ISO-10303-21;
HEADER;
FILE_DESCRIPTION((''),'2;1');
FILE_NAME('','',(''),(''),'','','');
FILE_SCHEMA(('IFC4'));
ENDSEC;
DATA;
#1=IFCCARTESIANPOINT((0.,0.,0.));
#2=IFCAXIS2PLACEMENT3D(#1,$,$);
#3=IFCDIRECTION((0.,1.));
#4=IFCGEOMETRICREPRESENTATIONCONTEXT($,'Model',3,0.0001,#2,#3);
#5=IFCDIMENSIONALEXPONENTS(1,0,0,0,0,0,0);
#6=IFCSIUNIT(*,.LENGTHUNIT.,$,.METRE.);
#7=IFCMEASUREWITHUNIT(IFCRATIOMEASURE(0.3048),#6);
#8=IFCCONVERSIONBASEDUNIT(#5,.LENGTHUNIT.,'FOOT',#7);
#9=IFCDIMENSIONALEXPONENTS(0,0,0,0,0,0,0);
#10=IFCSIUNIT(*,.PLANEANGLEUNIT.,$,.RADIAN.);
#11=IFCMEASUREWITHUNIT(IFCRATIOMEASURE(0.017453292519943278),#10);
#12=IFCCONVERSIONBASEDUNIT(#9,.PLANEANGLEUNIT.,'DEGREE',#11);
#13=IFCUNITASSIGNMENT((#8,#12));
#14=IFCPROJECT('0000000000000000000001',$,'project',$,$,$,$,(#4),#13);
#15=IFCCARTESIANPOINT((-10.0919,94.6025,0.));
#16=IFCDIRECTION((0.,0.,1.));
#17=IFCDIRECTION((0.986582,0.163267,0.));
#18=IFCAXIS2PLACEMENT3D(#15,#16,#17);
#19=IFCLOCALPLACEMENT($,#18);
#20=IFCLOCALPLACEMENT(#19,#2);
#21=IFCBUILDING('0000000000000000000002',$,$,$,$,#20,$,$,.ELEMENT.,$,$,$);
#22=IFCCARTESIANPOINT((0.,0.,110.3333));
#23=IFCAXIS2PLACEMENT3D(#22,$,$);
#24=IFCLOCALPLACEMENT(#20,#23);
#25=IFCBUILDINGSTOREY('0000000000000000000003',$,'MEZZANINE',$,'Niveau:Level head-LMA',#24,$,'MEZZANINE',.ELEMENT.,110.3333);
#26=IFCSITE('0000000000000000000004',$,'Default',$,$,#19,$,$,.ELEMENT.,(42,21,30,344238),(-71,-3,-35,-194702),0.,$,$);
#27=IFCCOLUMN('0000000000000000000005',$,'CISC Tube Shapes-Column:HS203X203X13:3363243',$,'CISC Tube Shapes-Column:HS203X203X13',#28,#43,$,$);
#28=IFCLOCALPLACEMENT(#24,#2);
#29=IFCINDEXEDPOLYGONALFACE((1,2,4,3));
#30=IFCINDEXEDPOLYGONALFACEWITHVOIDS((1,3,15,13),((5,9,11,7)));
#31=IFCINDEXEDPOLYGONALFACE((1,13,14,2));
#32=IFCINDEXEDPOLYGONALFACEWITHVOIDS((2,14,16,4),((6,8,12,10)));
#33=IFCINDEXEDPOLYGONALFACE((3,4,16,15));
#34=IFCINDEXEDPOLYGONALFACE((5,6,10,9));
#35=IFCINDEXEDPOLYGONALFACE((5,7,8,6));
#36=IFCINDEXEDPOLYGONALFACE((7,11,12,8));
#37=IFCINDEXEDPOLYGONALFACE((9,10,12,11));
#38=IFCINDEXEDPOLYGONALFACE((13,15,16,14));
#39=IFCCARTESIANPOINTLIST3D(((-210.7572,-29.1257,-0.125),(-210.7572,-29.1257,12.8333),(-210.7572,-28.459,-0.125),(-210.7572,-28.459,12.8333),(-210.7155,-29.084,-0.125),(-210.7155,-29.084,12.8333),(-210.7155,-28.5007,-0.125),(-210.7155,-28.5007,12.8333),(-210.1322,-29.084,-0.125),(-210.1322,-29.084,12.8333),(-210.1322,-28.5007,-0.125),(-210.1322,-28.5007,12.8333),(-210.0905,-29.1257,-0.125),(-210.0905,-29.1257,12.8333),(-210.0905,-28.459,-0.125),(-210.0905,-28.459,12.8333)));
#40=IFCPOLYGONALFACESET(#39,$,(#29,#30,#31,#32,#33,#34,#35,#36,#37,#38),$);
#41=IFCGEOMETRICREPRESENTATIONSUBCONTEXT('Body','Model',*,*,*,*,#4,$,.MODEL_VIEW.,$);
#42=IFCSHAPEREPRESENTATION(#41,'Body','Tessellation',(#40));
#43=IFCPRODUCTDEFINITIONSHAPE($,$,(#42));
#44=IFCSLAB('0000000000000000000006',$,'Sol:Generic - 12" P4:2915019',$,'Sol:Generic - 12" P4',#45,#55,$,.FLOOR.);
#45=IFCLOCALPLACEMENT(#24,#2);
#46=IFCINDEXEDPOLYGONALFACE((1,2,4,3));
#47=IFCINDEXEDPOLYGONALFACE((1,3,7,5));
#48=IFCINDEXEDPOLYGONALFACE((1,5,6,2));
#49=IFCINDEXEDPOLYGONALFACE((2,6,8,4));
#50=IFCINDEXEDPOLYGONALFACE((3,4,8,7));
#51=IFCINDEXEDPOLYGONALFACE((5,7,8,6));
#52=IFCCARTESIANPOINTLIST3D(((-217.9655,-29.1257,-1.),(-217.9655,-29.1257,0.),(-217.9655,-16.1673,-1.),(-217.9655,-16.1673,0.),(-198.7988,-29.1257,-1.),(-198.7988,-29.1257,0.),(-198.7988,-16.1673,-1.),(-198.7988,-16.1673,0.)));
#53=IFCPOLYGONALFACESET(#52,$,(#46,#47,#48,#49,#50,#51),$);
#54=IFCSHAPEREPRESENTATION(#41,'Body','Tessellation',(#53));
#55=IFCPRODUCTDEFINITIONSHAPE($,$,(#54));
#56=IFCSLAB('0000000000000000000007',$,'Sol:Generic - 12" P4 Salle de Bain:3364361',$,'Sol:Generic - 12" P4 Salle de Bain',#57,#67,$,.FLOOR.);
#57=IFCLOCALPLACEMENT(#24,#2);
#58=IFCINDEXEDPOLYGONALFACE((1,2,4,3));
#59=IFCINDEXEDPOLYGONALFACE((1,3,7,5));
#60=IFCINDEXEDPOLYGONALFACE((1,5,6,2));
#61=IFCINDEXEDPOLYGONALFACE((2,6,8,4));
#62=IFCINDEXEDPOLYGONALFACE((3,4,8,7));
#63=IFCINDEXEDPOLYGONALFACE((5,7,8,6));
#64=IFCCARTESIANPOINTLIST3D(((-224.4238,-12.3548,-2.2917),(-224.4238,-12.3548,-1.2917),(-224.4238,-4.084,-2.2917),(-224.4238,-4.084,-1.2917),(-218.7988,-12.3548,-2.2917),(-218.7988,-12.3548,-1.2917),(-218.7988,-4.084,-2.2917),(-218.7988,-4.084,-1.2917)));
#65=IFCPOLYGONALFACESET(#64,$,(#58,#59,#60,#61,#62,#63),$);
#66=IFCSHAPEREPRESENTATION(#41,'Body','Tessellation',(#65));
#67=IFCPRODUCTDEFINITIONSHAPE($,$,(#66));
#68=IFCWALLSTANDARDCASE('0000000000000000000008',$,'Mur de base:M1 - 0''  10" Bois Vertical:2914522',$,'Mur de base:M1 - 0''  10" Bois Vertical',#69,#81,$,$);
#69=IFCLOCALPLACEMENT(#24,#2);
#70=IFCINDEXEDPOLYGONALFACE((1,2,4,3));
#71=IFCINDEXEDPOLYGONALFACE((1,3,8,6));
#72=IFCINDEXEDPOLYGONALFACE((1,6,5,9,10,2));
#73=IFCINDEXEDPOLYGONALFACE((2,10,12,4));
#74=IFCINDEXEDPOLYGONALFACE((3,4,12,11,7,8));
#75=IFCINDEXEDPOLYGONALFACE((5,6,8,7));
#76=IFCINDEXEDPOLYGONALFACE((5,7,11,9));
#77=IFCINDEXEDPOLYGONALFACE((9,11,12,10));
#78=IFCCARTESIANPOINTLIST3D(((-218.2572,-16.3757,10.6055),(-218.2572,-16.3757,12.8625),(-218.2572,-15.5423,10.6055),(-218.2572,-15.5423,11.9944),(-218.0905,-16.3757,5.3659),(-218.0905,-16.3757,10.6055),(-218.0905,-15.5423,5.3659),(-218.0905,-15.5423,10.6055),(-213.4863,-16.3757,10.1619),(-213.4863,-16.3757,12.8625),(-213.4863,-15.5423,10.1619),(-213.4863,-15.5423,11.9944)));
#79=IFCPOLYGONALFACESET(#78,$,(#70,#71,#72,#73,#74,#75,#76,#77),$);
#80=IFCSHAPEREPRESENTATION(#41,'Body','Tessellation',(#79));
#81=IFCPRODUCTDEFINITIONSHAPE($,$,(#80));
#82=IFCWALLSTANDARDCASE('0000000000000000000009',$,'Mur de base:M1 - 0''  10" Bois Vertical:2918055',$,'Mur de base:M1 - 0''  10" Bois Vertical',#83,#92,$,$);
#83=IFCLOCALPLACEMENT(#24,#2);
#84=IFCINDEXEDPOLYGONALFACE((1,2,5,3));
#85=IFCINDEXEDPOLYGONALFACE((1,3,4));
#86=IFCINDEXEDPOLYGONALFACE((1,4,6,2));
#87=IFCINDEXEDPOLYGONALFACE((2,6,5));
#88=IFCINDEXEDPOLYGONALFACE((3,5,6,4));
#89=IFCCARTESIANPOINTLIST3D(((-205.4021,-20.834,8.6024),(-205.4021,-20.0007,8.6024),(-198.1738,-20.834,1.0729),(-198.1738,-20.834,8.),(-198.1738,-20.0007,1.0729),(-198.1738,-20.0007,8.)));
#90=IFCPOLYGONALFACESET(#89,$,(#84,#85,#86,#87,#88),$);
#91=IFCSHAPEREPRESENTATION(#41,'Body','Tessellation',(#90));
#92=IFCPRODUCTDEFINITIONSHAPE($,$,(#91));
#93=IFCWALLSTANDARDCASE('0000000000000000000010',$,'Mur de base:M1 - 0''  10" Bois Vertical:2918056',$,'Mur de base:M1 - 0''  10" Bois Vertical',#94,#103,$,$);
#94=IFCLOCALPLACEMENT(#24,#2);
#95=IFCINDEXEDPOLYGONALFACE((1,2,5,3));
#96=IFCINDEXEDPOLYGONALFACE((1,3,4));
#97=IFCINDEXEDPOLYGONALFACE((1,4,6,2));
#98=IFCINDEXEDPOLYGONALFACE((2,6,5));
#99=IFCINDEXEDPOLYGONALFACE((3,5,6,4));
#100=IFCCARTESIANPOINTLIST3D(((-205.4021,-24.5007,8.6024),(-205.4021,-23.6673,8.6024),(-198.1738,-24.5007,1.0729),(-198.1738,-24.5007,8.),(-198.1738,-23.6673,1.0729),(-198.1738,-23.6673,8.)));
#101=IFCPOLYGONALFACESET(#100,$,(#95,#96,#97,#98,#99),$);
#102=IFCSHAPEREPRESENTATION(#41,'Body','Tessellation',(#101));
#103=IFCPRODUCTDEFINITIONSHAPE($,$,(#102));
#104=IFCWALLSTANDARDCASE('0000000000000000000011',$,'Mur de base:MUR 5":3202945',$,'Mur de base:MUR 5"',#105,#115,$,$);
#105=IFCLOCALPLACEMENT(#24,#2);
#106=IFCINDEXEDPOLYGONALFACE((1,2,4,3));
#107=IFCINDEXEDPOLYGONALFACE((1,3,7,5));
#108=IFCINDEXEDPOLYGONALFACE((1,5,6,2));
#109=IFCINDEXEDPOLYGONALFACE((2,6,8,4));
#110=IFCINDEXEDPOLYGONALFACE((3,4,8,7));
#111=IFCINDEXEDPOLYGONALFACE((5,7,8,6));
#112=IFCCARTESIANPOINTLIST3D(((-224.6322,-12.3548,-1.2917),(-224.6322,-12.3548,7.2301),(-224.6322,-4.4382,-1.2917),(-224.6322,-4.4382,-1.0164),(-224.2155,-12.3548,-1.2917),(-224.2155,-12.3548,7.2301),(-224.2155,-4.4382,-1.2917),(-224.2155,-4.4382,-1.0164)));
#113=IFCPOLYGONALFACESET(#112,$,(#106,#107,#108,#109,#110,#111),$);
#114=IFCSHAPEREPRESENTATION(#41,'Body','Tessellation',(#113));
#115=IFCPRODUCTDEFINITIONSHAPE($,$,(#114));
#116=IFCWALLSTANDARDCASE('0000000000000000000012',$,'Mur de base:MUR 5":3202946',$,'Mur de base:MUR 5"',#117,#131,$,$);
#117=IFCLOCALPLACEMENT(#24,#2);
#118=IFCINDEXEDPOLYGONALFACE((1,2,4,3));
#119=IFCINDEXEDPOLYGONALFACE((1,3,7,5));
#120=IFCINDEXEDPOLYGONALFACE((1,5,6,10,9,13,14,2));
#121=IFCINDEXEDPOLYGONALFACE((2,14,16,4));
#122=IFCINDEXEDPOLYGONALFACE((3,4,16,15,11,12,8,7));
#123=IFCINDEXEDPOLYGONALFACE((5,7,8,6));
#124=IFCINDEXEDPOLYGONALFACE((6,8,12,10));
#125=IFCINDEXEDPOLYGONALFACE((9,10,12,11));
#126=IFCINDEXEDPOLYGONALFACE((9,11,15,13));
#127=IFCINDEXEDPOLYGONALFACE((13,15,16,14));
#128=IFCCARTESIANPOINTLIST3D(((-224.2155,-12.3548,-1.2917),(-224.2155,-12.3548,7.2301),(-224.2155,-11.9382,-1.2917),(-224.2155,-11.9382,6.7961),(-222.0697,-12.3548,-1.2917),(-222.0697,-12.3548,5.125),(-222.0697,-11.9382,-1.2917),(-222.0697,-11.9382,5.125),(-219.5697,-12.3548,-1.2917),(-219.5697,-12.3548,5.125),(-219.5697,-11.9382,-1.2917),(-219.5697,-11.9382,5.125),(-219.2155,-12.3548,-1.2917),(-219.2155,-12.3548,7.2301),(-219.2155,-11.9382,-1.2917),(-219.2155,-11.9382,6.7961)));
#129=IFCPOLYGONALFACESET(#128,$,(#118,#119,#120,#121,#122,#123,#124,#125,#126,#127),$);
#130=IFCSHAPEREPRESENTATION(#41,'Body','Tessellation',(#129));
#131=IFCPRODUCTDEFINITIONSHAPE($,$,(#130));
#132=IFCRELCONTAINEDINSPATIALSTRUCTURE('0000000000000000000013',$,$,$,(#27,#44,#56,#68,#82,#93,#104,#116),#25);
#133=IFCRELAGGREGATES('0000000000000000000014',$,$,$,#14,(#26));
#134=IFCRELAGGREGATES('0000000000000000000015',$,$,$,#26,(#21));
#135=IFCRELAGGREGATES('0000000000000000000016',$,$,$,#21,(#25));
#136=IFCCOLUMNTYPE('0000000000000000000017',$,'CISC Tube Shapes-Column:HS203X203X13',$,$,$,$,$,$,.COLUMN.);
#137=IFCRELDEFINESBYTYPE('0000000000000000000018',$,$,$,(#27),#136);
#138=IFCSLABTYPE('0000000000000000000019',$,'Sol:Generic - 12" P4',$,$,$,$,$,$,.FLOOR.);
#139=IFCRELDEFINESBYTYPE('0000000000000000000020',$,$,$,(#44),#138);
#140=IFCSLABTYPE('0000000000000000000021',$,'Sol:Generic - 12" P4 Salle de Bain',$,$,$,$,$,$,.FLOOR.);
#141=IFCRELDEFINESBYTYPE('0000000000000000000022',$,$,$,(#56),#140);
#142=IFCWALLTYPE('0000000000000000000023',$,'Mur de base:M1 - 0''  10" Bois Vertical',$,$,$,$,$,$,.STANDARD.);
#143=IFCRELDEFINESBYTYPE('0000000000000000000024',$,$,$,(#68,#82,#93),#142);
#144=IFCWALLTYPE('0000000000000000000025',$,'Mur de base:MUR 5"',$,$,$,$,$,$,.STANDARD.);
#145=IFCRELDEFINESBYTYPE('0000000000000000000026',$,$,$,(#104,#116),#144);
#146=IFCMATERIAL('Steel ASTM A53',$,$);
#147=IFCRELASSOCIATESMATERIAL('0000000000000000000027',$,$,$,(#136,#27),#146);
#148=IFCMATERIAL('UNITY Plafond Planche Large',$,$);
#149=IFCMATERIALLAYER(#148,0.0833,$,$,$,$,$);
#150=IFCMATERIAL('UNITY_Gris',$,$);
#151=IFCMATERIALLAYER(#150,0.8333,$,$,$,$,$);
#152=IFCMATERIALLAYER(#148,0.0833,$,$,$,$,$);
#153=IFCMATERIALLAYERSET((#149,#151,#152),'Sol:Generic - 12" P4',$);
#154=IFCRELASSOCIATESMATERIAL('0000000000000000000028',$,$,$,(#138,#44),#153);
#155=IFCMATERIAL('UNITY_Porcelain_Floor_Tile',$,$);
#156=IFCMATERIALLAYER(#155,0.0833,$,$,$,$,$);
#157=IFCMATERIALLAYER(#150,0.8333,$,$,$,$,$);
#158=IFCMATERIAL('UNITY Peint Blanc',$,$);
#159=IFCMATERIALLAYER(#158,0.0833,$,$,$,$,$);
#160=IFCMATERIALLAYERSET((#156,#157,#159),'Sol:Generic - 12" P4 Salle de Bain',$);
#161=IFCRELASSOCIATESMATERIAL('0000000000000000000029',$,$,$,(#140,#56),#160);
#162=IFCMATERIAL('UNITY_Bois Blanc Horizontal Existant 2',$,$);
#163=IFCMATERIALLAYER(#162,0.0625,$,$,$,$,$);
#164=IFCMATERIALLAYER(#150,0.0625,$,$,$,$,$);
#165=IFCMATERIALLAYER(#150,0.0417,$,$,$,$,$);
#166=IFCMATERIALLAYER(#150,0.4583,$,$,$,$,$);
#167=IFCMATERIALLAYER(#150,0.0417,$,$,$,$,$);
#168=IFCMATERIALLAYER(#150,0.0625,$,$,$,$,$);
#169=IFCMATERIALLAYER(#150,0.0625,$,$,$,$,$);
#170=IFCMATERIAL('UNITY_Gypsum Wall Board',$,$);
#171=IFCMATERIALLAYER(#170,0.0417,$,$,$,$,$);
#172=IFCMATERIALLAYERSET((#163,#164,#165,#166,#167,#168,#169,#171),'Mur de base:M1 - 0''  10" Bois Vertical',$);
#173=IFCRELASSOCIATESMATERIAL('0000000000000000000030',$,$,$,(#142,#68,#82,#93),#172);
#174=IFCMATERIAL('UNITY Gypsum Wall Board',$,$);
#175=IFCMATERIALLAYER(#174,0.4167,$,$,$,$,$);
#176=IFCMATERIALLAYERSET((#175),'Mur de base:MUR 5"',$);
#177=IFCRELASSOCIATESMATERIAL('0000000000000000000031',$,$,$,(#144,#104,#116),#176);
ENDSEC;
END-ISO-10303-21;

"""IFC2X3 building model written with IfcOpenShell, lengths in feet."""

from ifc_helpers import new_model, entity, si_unit, converted_unit, direction, frame, frame_2d, origin, origin_2d_with_axis, place, context, subcontext, project, spatial, polyline, rectangle, outline, extrude, clip, bounded_halfspace, source, transform, mapped, material, layer, layer_set, layer_usage, type_object, type_shapes, element, save


model = new_model("IFC2X3")

# Units and contexts
model_context = context("Model", 3, precision=0.0001, world=origin(), true_north=direction((0.0, 1.0)))
body_context = subcontext(model_context, "Body", "Model", "MODEL_VIEW")
ifc_project = project(units=[converted_unit("LENGTHUNIT", "FOOT", entity("IfcRatioMeasure", 0.3048), si_unit("LENGTHUNIT", "METRE"), dimensions=[1, 0, 0, 0, 0, 0, 0]), converted_unit("PLANEANGLEUNIT", "DEGREE", entity("IfcRatioMeasure", 0.017453292519943278), si_unit("PLANEANGLEUNIT", "RADIAN"), dimensions=[0, 0, 0, 0, 0, 0, 0])], contexts=[model_context])

# Site, building, storey
site_placement = place(None, frame((-10.0919, 94.6025, 0.0), z_axis=(0.0, 0.0, 1.0), x_axis=(0.986582, 0.163267, 0.0)))
site = spatial("IfcSite", under=ifc_project, at=site_placement, Name="Default", CompositionType="ELEMENT", RefLatitude=(42, 21, 30, 344238), RefLongitude=(-71, -3, -35, -194702), RefElevation=0.0)
building_placement = place(site_placement, origin())
building = spatial("IfcBuilding", under=site, at=building_placement, CompositionType="ELEMENT")
storey_placement = place(building_placement, frame((0.0, 0.0, 110.3333)))
storey = spatial("IfcBuildingStorey", under=building, at=storey_placement, Name="MEZZANINE", ObjectType="Niveau:Level head-LMA", LongName="MEZZANINE", CompositionType="ELEMENT", Elevation=110.3333)

# Column
ifc_material_1 = material(Name="Steel ASTM A53")
column_type = type_object("IfcColumnType", Name="CISC Tube Shapes-Column:HS203X203X13", PredefinedType="COLUMN", material=ifc_material_1)
shared_shape_1 = source(origin(), body_context, "Body", "SweptSolid", [
    extrude(outline(polyline([(-0.3333, -0.3333), (0.3333, -0.3333), (0.3333, 0.3333), (-0.3333, 0.3333), (-0.3333, -0.3333)]), holes=[polyline([(-0.2917, -0.2917), (-0.2917, 0.2917), (0.2917, 0.2917), (0.2917, -0.2917), (-0.2917, -0.2917)])]), frame((0.0, 0.0, 110.2083), z_axis=(0.0, 0.0, 1.0), x_axis=(-1.0, 0.0, 0.0)), (0.0, 0.0, 1.0), 12.9583),
])
type_shapes(column_type, [shared_shape_1])
column_placement = place(storey_placement, frame((-210.4238, -28.7923, -110.3333)))
element("IfcColumn", 1, at=column_placement, inside=storey, type_object=column_type, material=ifc_material_1, Name="CISC Tube Shapes-Column:HS203X203X13:3363243", ObjectType="CISC Tube Shapes-Column:HS203X203X13", context=body_context, shape_type="MappedRepresentation", body=[
    mapped(shared_shape_1, transform((0.0, 0.0, 0.0), scale=1.0)),
])

# Slabs
ifc_material_2 = material(Name="UNITY Plafond Planche Large")
ifc_layer_1 = layer(ifc_material_2, 0.0833)
ifc_material_3 = material(Name="UNITY_Gris")
ifc_layer_2 = layer(ifc_material_3, 0.8333)
ifc_layer_3 = layer(ifc_material_2, 0.0833)
ifc_layer_set_1 = layer_set([ifc_layer_1, ifc_layer_2, ifc_layer_3], Name="Sol:Generic - 12\" P4")
ifc_layer_usage_1 = layer_usage(ifc_layer_set_1, "AXIS3", "POSITIVE", 0.0)
slab_type_1 = type_object("IfcSlabType", Name="Sol:Generic - 12\" P4", PredefinedType="FLOOR", material=ifc_layer_set_1)
slab_1_placement = place(storey_placement, origin())
element("IfcSlab", 2, at=slab_1_placement, inside=storey, type_object=slab_type_1, material=ifc_layer_usage_1, Name="Sol:Generic - 12\" P4:2915019", ObjectType="Sol:Generic - 12\" P4", PredefinedType="FLOOR", context=body_context, shape_type="SweptSolid", body=[
    extrude(rectangle(XDim=12.9583, YDim=19.1666, at=origin_2d_with_axis()), frame((-208.3822, -22.6465, 0.0), z_axis=(0.0, 0.0, -1.0), x_axis=(0.0, 1.0, 0.0)), (0.0, 0.0, 1.0), 1.0),
])
ifc_material_4 = material(Name="UNITY Peint Blanc")
ifc_material_5 = material(Name="UNITY_Porcelain_Floor_Tile")
ifc_layer_4 = layer(ifc_material_5, 0.0833)
ifc_layer_5 = layer(ifc_material_3, 0.8333)
ifc_layer_6 = layer(ifc_material_4, 0.0833)
ifc_layer_set_2 = layer_set([ifc_layer_4, ifc_layer_5, ifc_layer_6], Name="Sol:Generic - 12\" P4 Salle de Bain")
ifc_layer_usage_2 = layer_usage(ifc_layer_set_2, "AXIS3", "POSITIVE", 0.0)
slab_type_2 = type_object("IfcSlabType", Name="Sol:Generic - 12\" P4 Salle de Bain", PredefinedType="FLOOR", material=ifc_layer_set_2)
slab_2_placement = place(storey_placement, origin())
element("IfcSlab", 3, at=slab_2_placement, inside=storey, type_object=slab_type_2, material=ifc_layer_usage_2, Name="Sol:Generic - 12\" P4 Salle de Bain:3364361", ObjectType="Sol:Generic - 12\" P4 Salle de Bain", PredefinedType="FLOOR", context=body_context, shape_type="SweptSolid", body=[
    extrude(rectangle(XDim=8.2708, YDim=5.625, at=frame_2d((0.0, 0.0), x_axis=(1.0, 0.0))), frame((-221.6113, -8.2194, -1.2917), z_axis=(0.0, 0.0, -1.0), x_axis=(0.0, 1.0, 0.0)), (0.0, 0.0, 1.0), 1.0),
])

# Shared definitions
ifc_material_6 = material(Name="UNITY_Bois Blanc Horizontal Existant 2")
ifc_material_7 = material(Name="UNITY_Gypsum Wall Board")

# Wall
ifc_layer_7 = layer(ifc_material_6, 0.0625)
ifc_layer_8 = layer(ifc_material_3, 0.0625)
ifc_layer_9 = layer(ifc_material_3, 0.0417)
ifc_layer_10 = layer(ifc_material_3, 0.4583)
ifc_layer_11 = layer(ifc_material_3, 0.0417)
ifc_layer_12 = layer(ifc_material_3, 0.0625)
ifc_layer_13 = layer(ifc_material_3, 0.0625)
ifc_layer_14 = layer(ifc_material_7, 0.0417)
ifc_layer_set_3 = layer_set([ifc_layer_7, ifc_layer_8, ifc_layer_9, ifc_layer_10, ifc_layer_11, ifc_layer_12, ifc_layer_13, ifc_layer_14], Name="Mur de base:M1 - 0'  10\" Bois Vertical")
ifc_layer_usage_3 = layer_usage(ifc_layer_set_3, "AXIS2", "NEGATIVE", 0.4167)
wall_type_1 = type_object("IfcWallType", Name="Mur de base:M1 - 0'  10\" Bois Vertical", PredefinedType="STANDARD", material=ifc_layer_set_3)
wall_1_placement = place(storey_placement, frame((-218.2572, -15.959, 5.3659)))
element("IfcWallStandardCase", 4, at=wall_1_placement, inside=storey, type_object=wall_type_1, material=ifc_layer_usage_3, Name="Mur de base:M1 - 0'  10\" Bois Vertical:2914522", ObjectType="Mur de base:M1 - 0'  10\" Bois Vertical", context=body_context, shape_type="Clipping", body=[
    clip(clip(clip(clip(extrude(rectangle(XDim=4.7708, YDim=0.8333, at=frame_2d((2.3854, 0.0), x_axis=(-1.0, 0.0))), origin(), (0.0, 0.0, 1.0), 7.4966), bounded_halfspace(frame((0.0, -0.4167, 7.4966), z_axis=(0.0, 0.721387, 0.692532), x_axis=(-1.0, 0.0, 0.0)), False, frame((0.0, -0.4167, 7.4966)), polyline([(0.0, 0.0), (4.7708, 0.0), (4.7708, 0.8333), (0.0, 0.8333), (0.0, 0.0)]))), bounded_halfspace(frame((4.7708, 0.4167, 4.796), z_axis=(-0.721387, 0.0, 0.692532), x_axis=(0.0, -1.0, 0.0)), True, frame((4.7708, 0.4167, 4.796)), polyline([(0.0, 0.0), (-4.6042, 0.0), (-4.6042, -0.8333), (0.0, -0.8333), (0.0, 0.0)]))), bounded_halfspace(frame((0.1667, 0.4167, 5.2396)), True, frame((0.1667, 0.4167, 5.2396)), polyline([(0.0, 0.0), (-0.1667, 0.0), (-0.1667, -0.8333), (0.0, -0.8333), (0.0, 0.0)]))), bounded_halfspace(frame((0.1667, -0.4167, 5.2396), z_axis=(1.0, 0.0, 0.0), x_axis=(0.0, 0.0, -1.0)), True, frame((0.1667, -0.4167, 5.2396), z_axis=(1.0, 0.0, 0.0), x_axis=(0.0, 0.0, -1.0)), polyline([(0.0, 0.0), (5.2396, 0.0), (5.2396, 0.8333), (0.0, 0.8333), (0.0, 0.0)]))),
])

# Walls, openings
ifc_layer_usage_4 = layer_usage(ifc_layer_set_3, "AXIS2", "POSITIVE", -0.4167)
wall_2_placement = place(storey_placement, frame((-198.1738, -20.4173, 1.0729), z_axis=(0.0, 0.0, 1.0), x_axis=(-1.0, 0.0, 0.0)))
wall_2 = element("IfcWallStandardCase", 5, at=wall_2_placement, inside=storey, type_object=wall_type_1, material=ifc_layer_usage_4, Name="Mur de base:M1 - 0'  10\" Bois Vertical:2918055", ObjectType="Mur de base:M1 - 0'  10\" Bois Vertical", context=body_context, shape_type="Clipping", body=[
    clip(clip(extrude(rectangle(XDim=7.2283, YDim=0.8333, at=frame_2d((3.6141, 0.0), x_axis=(-1.0, 0.0))), origin(), (0.0, 0.0, 1.0), 7.5294), bounded_halfspace(frame((0.0, -0.4167, 6.9271), z_axis=(-0.083045, 0.0, 0.996546), x_axis=(0.0, -1.0, 0.0)), False, frame((0.0, -0.4167, 6.9271)), polyline([(0.0, 0.0), (7.2283, 0.0), (7.2283, 0.8333), (0.8333, 0.8333), (0.0, 0.8333), (0.0, 0.0)]))), bounded_halfspace(frame((7.2283, -0.4167, 7.5294), z_axis=(-0.721387, 0.0, 0.692532), x_axis=(0.0, -1.0, 0.0)), True, frame((7.2283, -0.4167, 7.5294)), polyline([(0.0, 0.0), (0.0, 0.8333), (-7.2283, 0.8333), (-7.2283, 0.0), (0.0, 0.0)]))),
])
opening_1_placement = place(wall_2_placement, origin())
element("IfcOpeningElement", 6, at=opening_1_placement, cuts=wall_2, ObjectType="Opening", context=body_context, shape_type="SweptSolid", body=[
    extrude(rectangle(XDim=6.5833, YDim=0.8333, at=frame_2d((0.0, 0.0), x_axis=(0.0, 1.0))), frame((0.4167, 0.4167, 3.6354), z_axis=(0.0, 1.0, 0.0), x_axis=(1.0, 0.0, 0.0)), (0.0, 0.0, 1.0), 2.8333),
])
ifc_layer_usage_5 = layer_usage(ifc_layer_set_3, "AXIS2", "NEGATIVE", 0.4167)
wall_3_placement = place(storey_placement, frame((-198.1738, -24.084, 1.0729), z_axis=(0.0, 0.0, 1.0), x_axis=(-1.0, 0.0, 0.0)))
wall_3 = element("IfcWallStandardCase", 7, at=wall_3_placement, inside=storey, type_object=wall_type_1, material=ifc_layer_usage_5, Name="Mur de base:M1 - 0'  10\" Bois Vertical:2918056", ObjectType="Mur de base:M1 - 0'  10\" Bois Vertical", context=body_context, shape_type="Clipping", body=[
    clip(clip(extrude(rectangle(XDim=7.2283, YDim=0.8333, at=frame_2d((3.6141, 0.0), x_axis=(-1.0, 0.0))), origin(), (0.0, 0.0, 1.0), 7.5294), bounded_halfspace(frame((0.0, 0.4167, 6.9271), z_axis=(-0.083045, 0.0, 0.996546), x_axis=(0.0, -1.0, 0.0)), False, frame((0.0, 0.4167, 6.9271)), polyline([(0.0, 0.0), (0.0, -0.8333), (0.8333, -0.8333), (7.2283, -0.8333), (7.2283, 0.0), (0.0, 0.0)]))), bounded_halfspace(frame((7.2283, -0.4167, 7.5294), z_axis=(-0.721387, 0.0, 0.692532), x_axis=(0.0, -1.0, 0.0)), True, frame((7.2283, -0.4167, 7.5294)), polyline([(0.0, 0.0), (0.0, 0.8333), (-7.2283, 0.8333), (-7.2283, 0.0), (0.0, 0.0)]))),
])
opening_2_placement = place(wall_3_placement, origin())
element("IfcOpeningElement", 8, at=opening_2_placement, cuts=wall_3, ObjectType="Opening", context=body_context, shape_type="SweptSolid", body=[
    extrude(rectangle(XDim=6.5833, YDim=0.8333, at=frame_2d((0.0, 0.0), x_axis=(0.0, 1.0))), frame((0.4167, -3.25, 3.6354), z_axis=(0.0, 1.0, 0.0), x_axis=(1.0, 0.0, 0.0)), (0.0, 0.0, 1.0), 2.8333),
])

# Wall
ifc_material_8 = material(Name="UNITY Gypsum Wall Board")
ifc_layer_15 = layer(ifc_material_8, 0.4167)
ifc_layer_set_4 = layer_set([ifc_layer_15], Name="Mur de base:MUR 5\"")
ifc_layer_usage_6 = layer_usage(ifc_layer_set_4, "AXIS2", "NEGATIVE", 0.2083)
wall_type_2 = type_object("IfcWallType", Name="Mur de base:MUR 5\"", PredefinedType="STANDARD", material=ifc_layer_set_4)
wall_4_placement = place(storey_placement, frame((-224.4238, -12.3548, -1.2917), z_axis=(0.0, 0.0, 1.0), x_axis=(0.0, 1.0, 0.0)))
element("IfcWallStandardCase", 9, at=wall_4_placement, inside=storey, type_object=wall_type_2, material=ifc_layer_usage_6, Name="Mur de base:MUR 5\":3202945", ObjectType="Mur de base:MUR 5\"", context=body_context, shape_type="Clipping", body=[
    clip(extrude(rectangle(XDim=7.9167, YDim=0.4167, at=frame_2d((3.9583, 0.0), x_axis=(-1.0, 0.0))), origin(), (0.0, 0.0, 1.0), 8.5218), bounded_halfspace(frame((0.0, -0.2083, 8.5218), z_axis=(0.721387, 0.0, 0.692532), x_axis=(0.0, 1.0, 0.0)), False, frame((0.0, -0.2083, 8.5218)), polyline([(0.0, 0.0), (0.4167, 0.0), (4.9167, 0.0), (5.3333, 0.0), (7.9167, 0.0), (7.9167, 0.4167), (0.0, 0.4167), (0.0, 0.0)]))),
])

# Wall, opening
ifc_layer_usage_7 = layer_usage(ifc_layer_set_4, "AXIS2", "POSITIVE", -0.2083)
wall_5_placement = place(storey_placement, frame((-224.2155, -12.1465, -1.2917)))
wall_5 = element("IfcWallStandardCase", 10, at=wall_5_placement, inside=storey, type_object=wall_type_2, material=ifc_layer_usage_7, Name="Mur de base:MUR 5\":3202946", ObjectType="Mur de base:MUR 5\"", context=body_context, shape_type="Clipping", body=[
    clip(extrude(rectangle(XDim=5.0, YDim=0.4167, at=frame_2d((2.5, 0.0), x_axis=(-1.0, 0.0))), origin(), (0.0, 0.0, 1.0), 8.5218), bounded_halfspace(frame((0.0, -0.2083, 8.5218), z_axis=(0.0, 0.721387, 0.692532), x_axis=(-1.0, 0.0, 0.0)), False, frame((0.0, -0.2083, 8.5218)), polyline([(0.0, 0.0), (5.0, 0.0), (5.0, 0.4167), (0.0, 0.4167), (0.0, 0.0)]))),
])
opening_3_placement = place(wall_5_placement, frame((224.2155, 12.1465, 1.2917)))
element("IfcOpeningElement", 11, at=opening_3_placement, cuts=wall_5, ObjectType="Opening", context=body_context, shape_type="SweptSolid", body=[
    extrude(rectangle(XDim=6.4167, YDim=2.5, at=frame_2d((0.0, 0.0), x_axis=(0.0, 1.0))), frame((-220.8197, -17.3548, 1.9167), z_axis=(0.0, 1.0, 0.0), x_axis=(-1.0, 0.0, 0.0)), (0.0, 0.0, 1.0), 10.0),
])

save(model, "model.ifc")
